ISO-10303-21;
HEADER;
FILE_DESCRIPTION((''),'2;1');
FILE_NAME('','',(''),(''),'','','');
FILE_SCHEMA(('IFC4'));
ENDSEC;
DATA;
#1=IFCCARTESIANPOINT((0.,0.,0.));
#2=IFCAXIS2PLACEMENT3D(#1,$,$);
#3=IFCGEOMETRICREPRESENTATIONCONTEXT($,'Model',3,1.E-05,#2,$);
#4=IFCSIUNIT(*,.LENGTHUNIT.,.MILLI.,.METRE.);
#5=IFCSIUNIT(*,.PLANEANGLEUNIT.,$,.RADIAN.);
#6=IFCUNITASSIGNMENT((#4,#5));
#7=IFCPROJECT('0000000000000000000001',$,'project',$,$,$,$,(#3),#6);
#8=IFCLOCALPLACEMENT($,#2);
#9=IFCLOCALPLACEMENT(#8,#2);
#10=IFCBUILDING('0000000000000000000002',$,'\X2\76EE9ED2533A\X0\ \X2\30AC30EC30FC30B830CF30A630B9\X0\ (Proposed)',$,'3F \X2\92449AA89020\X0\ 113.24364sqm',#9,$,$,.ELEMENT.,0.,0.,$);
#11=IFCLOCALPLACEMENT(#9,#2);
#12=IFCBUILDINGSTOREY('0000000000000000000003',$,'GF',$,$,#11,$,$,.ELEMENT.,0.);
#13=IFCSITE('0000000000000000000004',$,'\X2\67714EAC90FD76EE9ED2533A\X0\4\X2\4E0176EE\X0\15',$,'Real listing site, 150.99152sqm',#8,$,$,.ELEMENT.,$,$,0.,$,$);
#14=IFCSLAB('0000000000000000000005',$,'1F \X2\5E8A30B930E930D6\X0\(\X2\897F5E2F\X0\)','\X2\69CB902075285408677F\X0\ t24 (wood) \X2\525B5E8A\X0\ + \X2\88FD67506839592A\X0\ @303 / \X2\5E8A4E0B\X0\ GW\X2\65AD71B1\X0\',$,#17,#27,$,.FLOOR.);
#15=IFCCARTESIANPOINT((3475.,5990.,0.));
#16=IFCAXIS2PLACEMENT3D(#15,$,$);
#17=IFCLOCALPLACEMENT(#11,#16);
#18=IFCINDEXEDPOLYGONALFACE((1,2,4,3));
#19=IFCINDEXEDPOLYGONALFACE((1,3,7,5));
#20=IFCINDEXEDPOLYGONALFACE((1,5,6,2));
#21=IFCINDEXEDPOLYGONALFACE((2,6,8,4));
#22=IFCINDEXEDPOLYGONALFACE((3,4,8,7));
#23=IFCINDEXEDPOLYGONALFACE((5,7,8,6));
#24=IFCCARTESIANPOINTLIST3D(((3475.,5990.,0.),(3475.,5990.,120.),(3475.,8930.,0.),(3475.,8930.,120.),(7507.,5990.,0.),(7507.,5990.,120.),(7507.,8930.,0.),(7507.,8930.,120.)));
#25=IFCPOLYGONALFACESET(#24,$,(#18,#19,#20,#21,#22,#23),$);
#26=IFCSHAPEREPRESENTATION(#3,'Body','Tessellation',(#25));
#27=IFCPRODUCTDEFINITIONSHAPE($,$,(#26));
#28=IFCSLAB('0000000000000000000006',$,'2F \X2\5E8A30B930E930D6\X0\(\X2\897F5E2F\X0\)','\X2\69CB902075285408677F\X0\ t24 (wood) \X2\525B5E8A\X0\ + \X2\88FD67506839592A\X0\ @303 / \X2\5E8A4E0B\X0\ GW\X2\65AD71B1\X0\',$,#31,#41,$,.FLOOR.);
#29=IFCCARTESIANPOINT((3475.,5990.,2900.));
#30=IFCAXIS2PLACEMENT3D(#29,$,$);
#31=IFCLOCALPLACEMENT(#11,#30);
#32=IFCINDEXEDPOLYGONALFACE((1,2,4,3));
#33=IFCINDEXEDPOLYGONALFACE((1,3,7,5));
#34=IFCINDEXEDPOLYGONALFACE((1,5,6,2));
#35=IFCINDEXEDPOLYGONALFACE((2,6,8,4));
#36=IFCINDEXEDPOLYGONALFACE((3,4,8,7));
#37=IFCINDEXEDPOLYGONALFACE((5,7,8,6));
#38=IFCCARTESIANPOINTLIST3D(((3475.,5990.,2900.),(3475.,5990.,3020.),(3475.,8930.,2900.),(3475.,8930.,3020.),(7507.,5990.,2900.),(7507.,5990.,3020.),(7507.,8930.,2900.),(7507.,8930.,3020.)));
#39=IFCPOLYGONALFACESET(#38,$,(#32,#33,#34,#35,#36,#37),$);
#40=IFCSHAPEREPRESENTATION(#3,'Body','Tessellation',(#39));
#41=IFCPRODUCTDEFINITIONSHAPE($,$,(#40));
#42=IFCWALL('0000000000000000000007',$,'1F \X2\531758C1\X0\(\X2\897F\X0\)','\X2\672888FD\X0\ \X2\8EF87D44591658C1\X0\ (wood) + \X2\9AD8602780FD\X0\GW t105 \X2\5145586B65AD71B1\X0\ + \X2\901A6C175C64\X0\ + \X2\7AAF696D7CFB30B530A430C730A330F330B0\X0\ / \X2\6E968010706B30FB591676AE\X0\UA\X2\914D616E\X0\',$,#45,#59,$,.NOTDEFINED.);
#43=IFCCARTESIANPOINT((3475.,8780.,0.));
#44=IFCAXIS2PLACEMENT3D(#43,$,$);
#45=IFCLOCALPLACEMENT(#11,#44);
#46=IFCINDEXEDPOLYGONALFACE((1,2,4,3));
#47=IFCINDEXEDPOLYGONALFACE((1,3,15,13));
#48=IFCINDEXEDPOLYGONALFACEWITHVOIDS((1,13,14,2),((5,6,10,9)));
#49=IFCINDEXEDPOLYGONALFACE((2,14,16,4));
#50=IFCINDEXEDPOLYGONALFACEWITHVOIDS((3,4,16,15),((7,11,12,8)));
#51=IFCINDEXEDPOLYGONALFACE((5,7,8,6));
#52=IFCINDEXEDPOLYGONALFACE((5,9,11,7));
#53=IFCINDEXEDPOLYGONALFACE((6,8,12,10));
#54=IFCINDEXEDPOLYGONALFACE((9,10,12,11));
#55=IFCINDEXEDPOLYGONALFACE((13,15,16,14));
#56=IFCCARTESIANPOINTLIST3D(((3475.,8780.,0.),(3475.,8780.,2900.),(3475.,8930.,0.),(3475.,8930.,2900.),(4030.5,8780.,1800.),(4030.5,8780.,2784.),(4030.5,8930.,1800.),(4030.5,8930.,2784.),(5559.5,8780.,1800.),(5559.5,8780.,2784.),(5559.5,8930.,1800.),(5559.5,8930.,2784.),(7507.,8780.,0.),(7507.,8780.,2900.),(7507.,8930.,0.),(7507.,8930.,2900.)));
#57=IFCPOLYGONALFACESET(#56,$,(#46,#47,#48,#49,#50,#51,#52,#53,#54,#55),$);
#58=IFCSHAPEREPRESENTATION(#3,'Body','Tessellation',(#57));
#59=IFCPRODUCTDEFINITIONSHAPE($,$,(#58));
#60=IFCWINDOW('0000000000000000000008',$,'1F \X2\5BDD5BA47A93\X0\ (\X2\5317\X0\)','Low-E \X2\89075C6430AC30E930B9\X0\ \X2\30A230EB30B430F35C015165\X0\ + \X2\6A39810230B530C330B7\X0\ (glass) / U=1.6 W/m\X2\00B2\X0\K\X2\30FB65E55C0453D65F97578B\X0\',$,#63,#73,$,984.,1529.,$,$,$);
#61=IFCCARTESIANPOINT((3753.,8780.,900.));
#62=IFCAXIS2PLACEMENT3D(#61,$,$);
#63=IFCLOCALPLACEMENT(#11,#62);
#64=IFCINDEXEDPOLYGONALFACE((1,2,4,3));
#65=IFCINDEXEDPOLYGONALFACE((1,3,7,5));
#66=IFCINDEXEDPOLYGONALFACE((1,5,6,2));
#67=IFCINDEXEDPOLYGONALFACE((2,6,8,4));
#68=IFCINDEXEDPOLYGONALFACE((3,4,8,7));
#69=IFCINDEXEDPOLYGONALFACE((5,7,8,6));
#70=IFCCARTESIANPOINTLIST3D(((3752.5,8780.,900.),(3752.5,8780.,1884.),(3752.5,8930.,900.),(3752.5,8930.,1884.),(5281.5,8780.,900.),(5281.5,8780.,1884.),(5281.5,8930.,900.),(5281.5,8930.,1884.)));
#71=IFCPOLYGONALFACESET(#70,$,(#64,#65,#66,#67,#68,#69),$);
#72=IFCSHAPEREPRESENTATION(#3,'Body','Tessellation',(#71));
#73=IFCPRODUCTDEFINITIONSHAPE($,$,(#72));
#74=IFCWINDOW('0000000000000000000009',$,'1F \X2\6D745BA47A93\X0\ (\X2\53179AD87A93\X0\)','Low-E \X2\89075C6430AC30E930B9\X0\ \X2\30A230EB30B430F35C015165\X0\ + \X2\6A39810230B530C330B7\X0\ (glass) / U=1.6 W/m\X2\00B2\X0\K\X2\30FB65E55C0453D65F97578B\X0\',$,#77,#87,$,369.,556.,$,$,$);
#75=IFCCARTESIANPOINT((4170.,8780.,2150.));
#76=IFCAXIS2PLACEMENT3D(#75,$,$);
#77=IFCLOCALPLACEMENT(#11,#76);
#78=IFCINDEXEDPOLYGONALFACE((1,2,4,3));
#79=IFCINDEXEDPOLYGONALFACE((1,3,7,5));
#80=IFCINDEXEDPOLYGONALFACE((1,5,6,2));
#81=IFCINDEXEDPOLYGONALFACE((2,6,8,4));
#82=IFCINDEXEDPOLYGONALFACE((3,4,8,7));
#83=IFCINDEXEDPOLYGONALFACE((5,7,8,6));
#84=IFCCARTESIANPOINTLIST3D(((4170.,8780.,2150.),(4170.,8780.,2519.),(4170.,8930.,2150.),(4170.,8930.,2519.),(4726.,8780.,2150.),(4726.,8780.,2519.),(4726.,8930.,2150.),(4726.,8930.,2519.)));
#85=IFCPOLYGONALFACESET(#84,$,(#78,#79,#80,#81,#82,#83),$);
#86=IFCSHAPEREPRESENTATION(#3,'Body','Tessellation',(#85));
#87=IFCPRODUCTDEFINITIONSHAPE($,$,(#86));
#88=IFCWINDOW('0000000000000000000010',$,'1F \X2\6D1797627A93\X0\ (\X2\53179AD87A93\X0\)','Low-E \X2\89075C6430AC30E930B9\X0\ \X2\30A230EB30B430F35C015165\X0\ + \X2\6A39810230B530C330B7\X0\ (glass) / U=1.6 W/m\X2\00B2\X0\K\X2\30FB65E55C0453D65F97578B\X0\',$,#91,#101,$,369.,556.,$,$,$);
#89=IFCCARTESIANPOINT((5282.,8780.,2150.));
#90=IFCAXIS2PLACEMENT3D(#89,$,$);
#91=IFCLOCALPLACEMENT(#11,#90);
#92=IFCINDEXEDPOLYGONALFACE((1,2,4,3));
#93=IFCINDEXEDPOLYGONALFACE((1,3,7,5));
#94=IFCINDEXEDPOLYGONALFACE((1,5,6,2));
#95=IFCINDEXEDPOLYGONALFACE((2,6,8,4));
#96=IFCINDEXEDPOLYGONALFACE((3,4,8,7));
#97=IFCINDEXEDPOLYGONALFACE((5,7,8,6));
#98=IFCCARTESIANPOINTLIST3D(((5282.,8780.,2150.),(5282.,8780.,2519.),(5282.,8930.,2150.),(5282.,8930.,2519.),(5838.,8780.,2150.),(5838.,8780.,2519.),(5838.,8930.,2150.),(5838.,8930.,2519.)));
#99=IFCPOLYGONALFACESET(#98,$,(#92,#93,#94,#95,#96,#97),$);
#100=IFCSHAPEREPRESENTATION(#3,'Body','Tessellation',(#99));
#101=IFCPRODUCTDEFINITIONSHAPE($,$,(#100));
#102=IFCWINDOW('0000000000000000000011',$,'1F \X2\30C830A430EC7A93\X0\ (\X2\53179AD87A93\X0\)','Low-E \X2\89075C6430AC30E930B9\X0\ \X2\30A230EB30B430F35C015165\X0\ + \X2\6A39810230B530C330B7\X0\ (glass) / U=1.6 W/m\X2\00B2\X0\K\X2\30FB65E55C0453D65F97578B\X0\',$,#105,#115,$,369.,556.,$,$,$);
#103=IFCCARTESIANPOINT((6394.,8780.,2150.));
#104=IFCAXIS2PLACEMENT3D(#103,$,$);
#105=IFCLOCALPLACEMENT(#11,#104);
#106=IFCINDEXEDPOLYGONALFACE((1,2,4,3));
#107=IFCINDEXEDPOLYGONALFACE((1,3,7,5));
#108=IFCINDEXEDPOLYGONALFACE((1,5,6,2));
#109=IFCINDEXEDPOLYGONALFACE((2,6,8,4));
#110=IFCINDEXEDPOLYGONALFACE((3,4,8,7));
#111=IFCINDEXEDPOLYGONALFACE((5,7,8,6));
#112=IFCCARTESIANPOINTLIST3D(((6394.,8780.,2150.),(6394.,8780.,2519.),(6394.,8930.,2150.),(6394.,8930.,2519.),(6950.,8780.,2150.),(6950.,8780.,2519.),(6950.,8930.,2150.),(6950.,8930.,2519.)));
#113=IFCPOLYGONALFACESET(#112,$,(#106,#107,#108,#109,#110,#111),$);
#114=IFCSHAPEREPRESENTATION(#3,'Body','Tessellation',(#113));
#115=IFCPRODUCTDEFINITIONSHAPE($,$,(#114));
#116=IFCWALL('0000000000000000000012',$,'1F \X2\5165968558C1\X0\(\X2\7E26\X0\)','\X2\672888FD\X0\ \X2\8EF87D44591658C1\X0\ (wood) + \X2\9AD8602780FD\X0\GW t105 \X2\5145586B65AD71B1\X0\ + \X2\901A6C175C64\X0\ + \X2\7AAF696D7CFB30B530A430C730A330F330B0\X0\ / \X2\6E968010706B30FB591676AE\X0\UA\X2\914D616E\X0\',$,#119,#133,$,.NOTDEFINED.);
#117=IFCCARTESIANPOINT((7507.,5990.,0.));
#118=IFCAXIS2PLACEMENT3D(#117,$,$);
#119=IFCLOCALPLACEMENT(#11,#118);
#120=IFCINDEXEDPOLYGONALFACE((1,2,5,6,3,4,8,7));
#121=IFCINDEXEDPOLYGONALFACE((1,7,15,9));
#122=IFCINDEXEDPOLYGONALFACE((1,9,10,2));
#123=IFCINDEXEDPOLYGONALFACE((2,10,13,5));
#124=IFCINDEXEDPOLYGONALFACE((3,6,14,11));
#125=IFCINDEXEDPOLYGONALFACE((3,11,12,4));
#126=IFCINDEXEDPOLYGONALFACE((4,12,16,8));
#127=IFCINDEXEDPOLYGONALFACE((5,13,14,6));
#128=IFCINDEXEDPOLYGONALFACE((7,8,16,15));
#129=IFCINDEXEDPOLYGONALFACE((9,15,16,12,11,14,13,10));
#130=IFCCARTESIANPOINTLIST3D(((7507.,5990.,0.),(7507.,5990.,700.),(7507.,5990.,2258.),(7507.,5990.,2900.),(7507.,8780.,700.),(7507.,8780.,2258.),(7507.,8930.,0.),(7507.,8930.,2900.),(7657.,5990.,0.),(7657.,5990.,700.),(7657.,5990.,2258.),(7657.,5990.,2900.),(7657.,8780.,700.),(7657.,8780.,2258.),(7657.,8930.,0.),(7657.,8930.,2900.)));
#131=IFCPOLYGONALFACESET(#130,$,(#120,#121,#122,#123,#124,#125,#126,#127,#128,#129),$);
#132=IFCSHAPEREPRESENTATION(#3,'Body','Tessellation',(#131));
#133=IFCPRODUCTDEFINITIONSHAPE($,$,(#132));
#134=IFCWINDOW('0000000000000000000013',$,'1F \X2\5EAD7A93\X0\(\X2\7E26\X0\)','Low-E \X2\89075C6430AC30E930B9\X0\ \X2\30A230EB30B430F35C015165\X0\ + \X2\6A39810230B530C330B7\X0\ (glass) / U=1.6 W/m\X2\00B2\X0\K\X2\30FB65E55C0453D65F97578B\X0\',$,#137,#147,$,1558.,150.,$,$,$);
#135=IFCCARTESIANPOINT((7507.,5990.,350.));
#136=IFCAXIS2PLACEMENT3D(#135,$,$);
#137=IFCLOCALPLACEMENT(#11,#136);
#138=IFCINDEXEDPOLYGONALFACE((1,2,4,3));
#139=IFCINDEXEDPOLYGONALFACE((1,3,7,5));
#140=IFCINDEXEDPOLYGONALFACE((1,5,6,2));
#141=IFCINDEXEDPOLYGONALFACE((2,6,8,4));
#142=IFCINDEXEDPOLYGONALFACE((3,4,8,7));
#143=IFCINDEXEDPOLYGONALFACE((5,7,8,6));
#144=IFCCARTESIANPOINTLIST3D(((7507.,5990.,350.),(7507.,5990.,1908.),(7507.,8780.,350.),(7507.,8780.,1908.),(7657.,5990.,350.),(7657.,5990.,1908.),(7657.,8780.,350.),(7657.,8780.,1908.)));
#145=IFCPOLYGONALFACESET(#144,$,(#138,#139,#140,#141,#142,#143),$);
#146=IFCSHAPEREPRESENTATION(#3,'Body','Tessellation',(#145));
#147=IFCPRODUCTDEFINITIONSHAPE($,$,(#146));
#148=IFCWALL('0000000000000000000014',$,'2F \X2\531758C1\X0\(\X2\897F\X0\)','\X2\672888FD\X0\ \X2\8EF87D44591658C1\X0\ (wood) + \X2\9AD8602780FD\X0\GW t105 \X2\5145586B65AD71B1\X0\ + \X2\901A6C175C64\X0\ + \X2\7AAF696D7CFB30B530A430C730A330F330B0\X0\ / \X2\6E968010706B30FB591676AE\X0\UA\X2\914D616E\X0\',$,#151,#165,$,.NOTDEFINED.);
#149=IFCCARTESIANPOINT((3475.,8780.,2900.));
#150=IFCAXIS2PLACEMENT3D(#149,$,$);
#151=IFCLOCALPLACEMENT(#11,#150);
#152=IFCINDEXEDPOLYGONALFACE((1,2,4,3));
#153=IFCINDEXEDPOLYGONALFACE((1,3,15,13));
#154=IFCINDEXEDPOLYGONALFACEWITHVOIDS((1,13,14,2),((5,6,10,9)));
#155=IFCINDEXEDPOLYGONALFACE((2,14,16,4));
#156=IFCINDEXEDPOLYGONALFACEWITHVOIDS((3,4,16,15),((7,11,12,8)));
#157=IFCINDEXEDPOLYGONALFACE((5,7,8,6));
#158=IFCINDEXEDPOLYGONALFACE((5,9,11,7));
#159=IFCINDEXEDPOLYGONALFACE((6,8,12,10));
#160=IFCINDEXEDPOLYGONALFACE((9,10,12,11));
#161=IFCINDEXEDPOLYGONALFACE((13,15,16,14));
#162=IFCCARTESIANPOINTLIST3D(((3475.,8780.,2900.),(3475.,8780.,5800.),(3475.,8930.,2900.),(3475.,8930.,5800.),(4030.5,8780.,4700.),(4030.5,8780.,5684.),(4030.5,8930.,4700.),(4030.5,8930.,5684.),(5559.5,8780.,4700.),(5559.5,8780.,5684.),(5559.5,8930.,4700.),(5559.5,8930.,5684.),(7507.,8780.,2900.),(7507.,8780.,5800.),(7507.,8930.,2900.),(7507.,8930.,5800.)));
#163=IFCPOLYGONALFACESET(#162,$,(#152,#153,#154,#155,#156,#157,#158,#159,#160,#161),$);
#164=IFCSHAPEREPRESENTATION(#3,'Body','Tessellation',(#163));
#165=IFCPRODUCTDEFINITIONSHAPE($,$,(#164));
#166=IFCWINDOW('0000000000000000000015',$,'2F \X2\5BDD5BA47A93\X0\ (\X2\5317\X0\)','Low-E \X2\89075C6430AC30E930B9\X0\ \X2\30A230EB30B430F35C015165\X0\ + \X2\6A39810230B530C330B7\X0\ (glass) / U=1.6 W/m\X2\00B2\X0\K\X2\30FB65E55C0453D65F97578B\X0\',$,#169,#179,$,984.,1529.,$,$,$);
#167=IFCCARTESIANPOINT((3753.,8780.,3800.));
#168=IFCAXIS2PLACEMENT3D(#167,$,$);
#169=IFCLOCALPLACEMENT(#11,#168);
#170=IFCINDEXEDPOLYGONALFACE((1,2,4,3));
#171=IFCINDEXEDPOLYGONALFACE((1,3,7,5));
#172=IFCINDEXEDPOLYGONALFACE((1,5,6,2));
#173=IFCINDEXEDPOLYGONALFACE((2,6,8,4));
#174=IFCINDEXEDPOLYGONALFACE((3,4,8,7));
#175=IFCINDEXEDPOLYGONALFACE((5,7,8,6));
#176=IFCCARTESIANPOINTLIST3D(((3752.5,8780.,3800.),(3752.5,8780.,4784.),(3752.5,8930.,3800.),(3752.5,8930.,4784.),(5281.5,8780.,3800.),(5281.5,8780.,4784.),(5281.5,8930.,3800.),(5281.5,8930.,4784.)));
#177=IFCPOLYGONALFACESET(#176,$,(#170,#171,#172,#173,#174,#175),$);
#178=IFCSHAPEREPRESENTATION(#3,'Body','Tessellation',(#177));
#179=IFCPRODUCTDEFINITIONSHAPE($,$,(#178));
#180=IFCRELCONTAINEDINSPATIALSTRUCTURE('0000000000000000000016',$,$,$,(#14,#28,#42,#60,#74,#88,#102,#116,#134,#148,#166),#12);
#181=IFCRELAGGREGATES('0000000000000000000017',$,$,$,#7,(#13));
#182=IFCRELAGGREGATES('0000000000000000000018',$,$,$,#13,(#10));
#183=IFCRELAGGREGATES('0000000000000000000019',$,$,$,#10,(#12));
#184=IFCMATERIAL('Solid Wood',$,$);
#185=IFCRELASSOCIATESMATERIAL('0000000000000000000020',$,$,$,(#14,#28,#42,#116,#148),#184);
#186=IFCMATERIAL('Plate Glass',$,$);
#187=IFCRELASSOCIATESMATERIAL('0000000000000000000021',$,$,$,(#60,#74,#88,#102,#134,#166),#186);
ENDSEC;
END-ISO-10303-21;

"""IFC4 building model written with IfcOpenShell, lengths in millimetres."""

from ifc_helpers import new_model, si_unit, frame, frame_2d, origin, place, context, project, spatial, rectangle, extrude, material, element, fill, save


model = new_model("IFC4")

# Units and contexts
model_context = context("Model", 3, precision=1e-05, world=origin())
ifc_project = project(units=[si_unit("LENGTHUNIT", "METRE", prefix="MILLI"), si_unit("PLANEANGLEUNIT", "RADIAN")], contexts=[model_context])

# Site, building, storey
site_placement = place(None, origin())
site = spatial("IfcSite", under=ifc_project, at=site_placement, Name="東京都目黒区4丁目15", ObjectType="Real listing site, 150.99152sqm", CompositionType="ELEMENT", RefElevation=0.0)
building_placement = place(site_placement, origin())
building = spatial("IfcBuilding", under=site, at=building_placement, Name="目黒区 ガレージハウス (Proposed)", ObjectType="3F 鉄骨造 113.24364sqm", CompositionType="ELEMENT", ElevationOfRefHeight=0.0, ElevationOfTerrain=0.0)
storey_placement = place(building_placement, origin())
storey = spatial("IfcBuildingStorey", under=building, at=storey_placement, Name="GF", CompositionType="ELEMENT", Elevation=0.0)

# Slabs
ifc_material_1 = material(Name="Solid Wood")
slab_1_placement = place(storey_placement, frame((3475.0, 5990.0, 0.0)))
element("IfcSlab", 1, at=slab_1_placement, inside=storey, material=ifc_material_1, Name="1F 床スラブ(西帯)", Description="構造用合板 t24 (wood) 剛床 + 製材根太 @303 / 床下 GW断熱", PredefinedType="FLOOR", context=model_context, shape_type="SweptSolid", body=[
    extrude(rectangle(XDim=4032.0, YDim=2940.0, at=frame_2d((2016.0, 1470.0))), frame((3475.0, 5990.0, 0.0)), (0.0, 0.0, 1.0), 120.0),
])
slab_2_placement = place(storey_placement, frame((3475.0, 5990.0, 2900.0)))
element("IfcSlab", 2, at=slab_2_placement, inside=storey, material=ifc_material_1, Name="2F 床スラブ(西帯)", Description="構造用合板 t24 (wood) 剛床 + 製材根太 @303 / 床下 GW断熱", PredefinedType="FLOOR", context=model_context, shape_type="SweptSolid", body=[
    extrude(rectangle(XDim=4032.0, YDim=2940.0, at=frame_2d((2016.0, 1470.0))), frame((3475.0, 5990.0, 2900.0)), (0.0, 0.0, 1.0), 120.0),
])

# Wall, openings, windows
wall_1_placement = place(storey_placement, frame((3475.0, 8780.0, 0.0)))
wall_1 = element("IfcWall", 3, at=wall_1_placement, inside=storey, material=ifc_material_1, Name="1F 北壁(西)", Description="木製 軸組外壁 (wood) + 高性能GW t105 充填断熱 + 通気層 + 窯業系サイディング / 準耐火・外皮UA配慮", PredefinedType="NOTDEFINED", context=model_context, shape_type="SweptSolid", body=[
    extrude(rectangle(XDim=4032.0, YDim=150.0, at=frame_2d((2016.0, 75.0))), frame((3475.0, 8780.0, 0.0)), (0.0, 0.0, 1.0), 2900.0),
])
opening_1_placement = place(storey_placement, frame((3753.0, 8780.0, 900.0)))
opening_1 = element("IfcOpeningElement", 4, at=opening_1_placement, cuts=wall_1, PredefinedType="NOTDEFINED", context=model_context, shape_type="SweptSolid", body=[
    extrude(rectangle(XDim=1529.0, YDim=150.0, at=frame_2d((764.0, 75.0))), frame((3753.0, 8780.0, 900.0)), (0.0, 0.0, 1.0), 984.0),
])
opening_2_placement = place(storey_placement, frame((4170.0, 8780.0, 2150.0)))
opening_2 = element("IfcOpeningElement", 5, at=opening_2_placement, cuts=wall_1, PredefinedType="NOTDEFINED", context=model_context, shape_type="SweptSolid", body=[
    extrude(rectangle(XDim=556.0, YDim=150.0, at=frame_2d((278.0, 75.0))), frame((4170.0, 8780.0, 2150.0)), (0.0, 0.0, 1.0), 369.0),
])
opening_3_placement = place(storey_placement, frame((5282.0, 8780.0, 2150.0)))
opening_3 = element("IfcOpeningElement", 6, at=opening_3_placement, cuts=wall_1, PredefinedType="NOTDEFINED", context=model_context, shape_type="SweptSolid", body=[
    extrude(rectangle(XDim=556.0, YDim=150.0, at=frame_2d((278.0, 75.0))), frame((5282.0, 8780.0, 2150.0)), (0.0, 0.0, 1.0), 369.0),
])
opening_4_placement = place(storey_placement, frame((6394.0, 8780.0, 2150.0)))
opening_4 = element("IfcOpeningElement", 7, at=opening_4_placement, cuts=wall_1, PredefinedType="NOTDEFINED", context=model_context, shape_type="SweptSolid", body=[
    extrude(rectangle(XDim=556.0, YDim=150.0, at=frame_2d((278.0, 75.0))), frame((6394.0, 8780.0, 2150.0)), (0.0, 0.0, 1.0), 369.0),
])
ifc_material_2 = material(Name="Plate Glass")
window_1_placement = place(storey_placement, frame((3753.0, 8780.0, 900.0)))
window_1 = element("IfcWindow", 8, at=window_1_placement, inside=storey, material=ifc_material_2, Name="1F 寝室窓 (北)", Description="Low-E 複層ガラス アルゴン封入 + 樹脂サッシ (glass) / U=1.6 W/m²K・日射取得型", OverallHeight=984.0, OverallWidth=1529.0, context=model_context, shape_type="SweptSolid", body=[
    extrude(rectangle(XDim=1529.0, YDim=150.0, at=frame_2d((764.0, 75.0))), frame((3753.0, 8780.0, 900.0)), (0.0, 0.0, 1.0), 984.0),
])
fill(opening_1, window_1)
window_2_placement = place(storey_placement, frame((4170.0, 8780.0, 2150.0)))
window_2 = element("IfcWindow", 9, at=window_2_placement, inside=storey, material=ifc_material_2, Name="1F 浴室窓 (北高窓)", Description="Low-E 複層ガラス アルゴン封入 + 樹脂サッシ (glass) / U=1.6 W/m²K・日射取得型", OverallHeight=369.0, OverallWidth=556.0, context=model_context, shape_type="SweptSolid", body=[
    extrude(rectangle(XDim=556.0, YDim=150.0, at=frame_2d((278.0, 75.0))), frame((4170.0, 8780.0, 2150.0)), (0.0, 0.0, 1.0), 369.0),
])
fill(opening_2, window_2)
window_3_placement = place(storey_placement, frame((5282.0, 8780.0, 2150.0)))
window_3 = element("IfcWindow", 10, at=window_3_placement, inside=storey, material=ifc_material_2, Name="1F 洗面窓 (北高窓)", Description="Low-E 複層ガラス アルゴン封入 + 樹脂サッシ (glass) / U=1.6 W/m²K・日射取得型", OverallHeight=369.0, OverallWidth=556.0, context=model_context, shape_type="SweptSolid", body=[
    extrude(rectangle(XDim=556.0, YDim=150.0, at=frame_2d((278.0, 75.0))), frame((5282.0, 8780.0, 2150.0)), (0.0, 0.0, 1.0), 369.0),
])
fill(opening_3, window_3)
window_4_placement = place(storey_placement, frame((6394.0, 8780.0, 2150.0)))
window_4 = element("IfcWindow", 11, at=window_4_placement, inside=storey, material=ifc_material_2, Name="1F トイレ窓 (北高窓)", Description="Low-E 複層ガラス アルゴン封入 + 樹脂サッシ (glass) / U=1.6 W/m²K・日射取得型", OverallHeight=369.0, OverallWidth=556.0, context=model_context, shape_type="SweptSolid", body=[
    extrude(rectangle(XDim=556.0, YDim=150.0, at=frame_2d((278.0, 75.0))), frame((6394.0, 8780.0, 2150.0)), (0.0, 0.0, 1.0), 369.0),
])
fill(opening_4, window_4)

# Wall, opening, window
wall_2_placement = place(storey_placement, frame((7507.0, 5990.0, 0.0)))
wall_2 = element("IfcWall", 12, at=wall_2_placement, inside=storey, material=ifc_material_1, Name="1F 入隅壁(縦)", Description="木製 軸組外壁 (wood) + 高性能GW t105 充填断熱 + 通気層 + 窯業系サイディング / 準耐火・外皮UA配慮", PredefinedType="NOTDEFINED", context=model_context, shape_type="SweptSolid", body=[
    extrude(rectangle(XDim=150.0, YDim=2940.0, at=frame_2d((75.0, 1470.0))), frame((7507.0, 5990.0, 0.0)), (0.0, 0.0, 1.0), 2900.0),
])
opening_5_placement = place(storey_placement, frame((7507.0, 5990.0, 350.0)))
opening_5 = element("IfcOpeningElement", 13, at=opening_5_placement, cuts=wall_2, PredefinedType="NOTDEFINED", context=model_context, shape_type="SweptSolid", body=[
    extrude(rectangle(XDim=150.0, YDim=2790.0, at=frame_2d((75.0, 1395.0))), frame((7507.0, 5990.0, 350.0)), (0.0, 0.0, 1.0), 1558.0),
])
window_5_placement = place(storey_placement, frame((7507.0, 5990.0, 350.0)))
window_5 = element("IfcWindow", 14, at=window_5_placement, inside=storey, material=ifc_material_2, Name="1F 庭窓(縦)", Description="Low-E 複層ガラス アルゴン封入 + 樹脂サッシ (glass) / U=1.6 W/m²K・日射取得型", OverallHeight=1558.0, OverallWidth=150.0, context=model_context, shape_type="SweptSolid", body=[
    extrude(rectangle(XDim=150.0, YDim=2790.0, at=frame_2d((75.0, 1395.0))), frame((7507.0, 5990.0, 350.0)), (0.0, 0.0, 1.0), 1558.0),
])
fill(opening_5, window_5)

# Wall, opening, window
wall_3_placement = place(storey_placement, frame((3475.0, 8780.0, 2900.0)))
wall_3 = element("IfcWall", 15, at=wall_3_placement, inside=storey, material=ifc_material_1, Name="2F 北壁(西)", Description="木製 軸組外壁 (wood) + 高性能GW t105 充填断熱 + 通気層 + 窯業系サイディング / 準耐火・外皮UA配慮", PredefinedType="NOTDEFINED", context=model_context, shape_type="SweptSolid", body=[
    extrude(rectangle(XDim=4032.0, YDim=150.0, at=frame_2d((2016.0, 75.0))), frame((3475.0, 8780.0, 2900.0)), (0.0, 0.0, 1.0), 2900.0),
])
opening_6_placement = place(storey_placement, frame((3753.0, 8780.0, 3800.0)))
opening_6 = element("IfcOpeningElement", 16, at=opening_6_placement, cuts=wall_3, PredefinedType="NOTDEFINED", context=model_context, shape_type="SweptSolid", body=[
    extrude(rectangle(XDim=1529.0, YDim=150.0, at=frame_2d((764.0, 75.0))), frame((3753.0, 8780.0, 3800.0)), (0.0, 0.0, 1.0), 984.0),
])
window_6_placement = place(storey_placement, frame((3753.0, 8780.0, 3800.0)))
window_6 = element("IfcWindow", 17, at=window_6_placement, inside=storey, material=ifc_material_2, Name="2F 寝室窓 (北)", Description="Low-E 複層ガラス アルゴン封入 + 樹脂サッシ (glass) / U=1.6 W/m²K・日射取得型", OverallHeight=984.0, OverallWidth=1529.0, context=model_context, shape_type="SweptSolid", body=[
    extrude(rectangle(XDim=1529.0, YDim=150.0, at=frame_2d((764.0, 75.0))), frame((3753.0, 8780.0, 3800.0)), (0.0, 0.0, 1.0), 984.0),
])
fill(opening_6, window_6)

save(model, "model.ifc")
